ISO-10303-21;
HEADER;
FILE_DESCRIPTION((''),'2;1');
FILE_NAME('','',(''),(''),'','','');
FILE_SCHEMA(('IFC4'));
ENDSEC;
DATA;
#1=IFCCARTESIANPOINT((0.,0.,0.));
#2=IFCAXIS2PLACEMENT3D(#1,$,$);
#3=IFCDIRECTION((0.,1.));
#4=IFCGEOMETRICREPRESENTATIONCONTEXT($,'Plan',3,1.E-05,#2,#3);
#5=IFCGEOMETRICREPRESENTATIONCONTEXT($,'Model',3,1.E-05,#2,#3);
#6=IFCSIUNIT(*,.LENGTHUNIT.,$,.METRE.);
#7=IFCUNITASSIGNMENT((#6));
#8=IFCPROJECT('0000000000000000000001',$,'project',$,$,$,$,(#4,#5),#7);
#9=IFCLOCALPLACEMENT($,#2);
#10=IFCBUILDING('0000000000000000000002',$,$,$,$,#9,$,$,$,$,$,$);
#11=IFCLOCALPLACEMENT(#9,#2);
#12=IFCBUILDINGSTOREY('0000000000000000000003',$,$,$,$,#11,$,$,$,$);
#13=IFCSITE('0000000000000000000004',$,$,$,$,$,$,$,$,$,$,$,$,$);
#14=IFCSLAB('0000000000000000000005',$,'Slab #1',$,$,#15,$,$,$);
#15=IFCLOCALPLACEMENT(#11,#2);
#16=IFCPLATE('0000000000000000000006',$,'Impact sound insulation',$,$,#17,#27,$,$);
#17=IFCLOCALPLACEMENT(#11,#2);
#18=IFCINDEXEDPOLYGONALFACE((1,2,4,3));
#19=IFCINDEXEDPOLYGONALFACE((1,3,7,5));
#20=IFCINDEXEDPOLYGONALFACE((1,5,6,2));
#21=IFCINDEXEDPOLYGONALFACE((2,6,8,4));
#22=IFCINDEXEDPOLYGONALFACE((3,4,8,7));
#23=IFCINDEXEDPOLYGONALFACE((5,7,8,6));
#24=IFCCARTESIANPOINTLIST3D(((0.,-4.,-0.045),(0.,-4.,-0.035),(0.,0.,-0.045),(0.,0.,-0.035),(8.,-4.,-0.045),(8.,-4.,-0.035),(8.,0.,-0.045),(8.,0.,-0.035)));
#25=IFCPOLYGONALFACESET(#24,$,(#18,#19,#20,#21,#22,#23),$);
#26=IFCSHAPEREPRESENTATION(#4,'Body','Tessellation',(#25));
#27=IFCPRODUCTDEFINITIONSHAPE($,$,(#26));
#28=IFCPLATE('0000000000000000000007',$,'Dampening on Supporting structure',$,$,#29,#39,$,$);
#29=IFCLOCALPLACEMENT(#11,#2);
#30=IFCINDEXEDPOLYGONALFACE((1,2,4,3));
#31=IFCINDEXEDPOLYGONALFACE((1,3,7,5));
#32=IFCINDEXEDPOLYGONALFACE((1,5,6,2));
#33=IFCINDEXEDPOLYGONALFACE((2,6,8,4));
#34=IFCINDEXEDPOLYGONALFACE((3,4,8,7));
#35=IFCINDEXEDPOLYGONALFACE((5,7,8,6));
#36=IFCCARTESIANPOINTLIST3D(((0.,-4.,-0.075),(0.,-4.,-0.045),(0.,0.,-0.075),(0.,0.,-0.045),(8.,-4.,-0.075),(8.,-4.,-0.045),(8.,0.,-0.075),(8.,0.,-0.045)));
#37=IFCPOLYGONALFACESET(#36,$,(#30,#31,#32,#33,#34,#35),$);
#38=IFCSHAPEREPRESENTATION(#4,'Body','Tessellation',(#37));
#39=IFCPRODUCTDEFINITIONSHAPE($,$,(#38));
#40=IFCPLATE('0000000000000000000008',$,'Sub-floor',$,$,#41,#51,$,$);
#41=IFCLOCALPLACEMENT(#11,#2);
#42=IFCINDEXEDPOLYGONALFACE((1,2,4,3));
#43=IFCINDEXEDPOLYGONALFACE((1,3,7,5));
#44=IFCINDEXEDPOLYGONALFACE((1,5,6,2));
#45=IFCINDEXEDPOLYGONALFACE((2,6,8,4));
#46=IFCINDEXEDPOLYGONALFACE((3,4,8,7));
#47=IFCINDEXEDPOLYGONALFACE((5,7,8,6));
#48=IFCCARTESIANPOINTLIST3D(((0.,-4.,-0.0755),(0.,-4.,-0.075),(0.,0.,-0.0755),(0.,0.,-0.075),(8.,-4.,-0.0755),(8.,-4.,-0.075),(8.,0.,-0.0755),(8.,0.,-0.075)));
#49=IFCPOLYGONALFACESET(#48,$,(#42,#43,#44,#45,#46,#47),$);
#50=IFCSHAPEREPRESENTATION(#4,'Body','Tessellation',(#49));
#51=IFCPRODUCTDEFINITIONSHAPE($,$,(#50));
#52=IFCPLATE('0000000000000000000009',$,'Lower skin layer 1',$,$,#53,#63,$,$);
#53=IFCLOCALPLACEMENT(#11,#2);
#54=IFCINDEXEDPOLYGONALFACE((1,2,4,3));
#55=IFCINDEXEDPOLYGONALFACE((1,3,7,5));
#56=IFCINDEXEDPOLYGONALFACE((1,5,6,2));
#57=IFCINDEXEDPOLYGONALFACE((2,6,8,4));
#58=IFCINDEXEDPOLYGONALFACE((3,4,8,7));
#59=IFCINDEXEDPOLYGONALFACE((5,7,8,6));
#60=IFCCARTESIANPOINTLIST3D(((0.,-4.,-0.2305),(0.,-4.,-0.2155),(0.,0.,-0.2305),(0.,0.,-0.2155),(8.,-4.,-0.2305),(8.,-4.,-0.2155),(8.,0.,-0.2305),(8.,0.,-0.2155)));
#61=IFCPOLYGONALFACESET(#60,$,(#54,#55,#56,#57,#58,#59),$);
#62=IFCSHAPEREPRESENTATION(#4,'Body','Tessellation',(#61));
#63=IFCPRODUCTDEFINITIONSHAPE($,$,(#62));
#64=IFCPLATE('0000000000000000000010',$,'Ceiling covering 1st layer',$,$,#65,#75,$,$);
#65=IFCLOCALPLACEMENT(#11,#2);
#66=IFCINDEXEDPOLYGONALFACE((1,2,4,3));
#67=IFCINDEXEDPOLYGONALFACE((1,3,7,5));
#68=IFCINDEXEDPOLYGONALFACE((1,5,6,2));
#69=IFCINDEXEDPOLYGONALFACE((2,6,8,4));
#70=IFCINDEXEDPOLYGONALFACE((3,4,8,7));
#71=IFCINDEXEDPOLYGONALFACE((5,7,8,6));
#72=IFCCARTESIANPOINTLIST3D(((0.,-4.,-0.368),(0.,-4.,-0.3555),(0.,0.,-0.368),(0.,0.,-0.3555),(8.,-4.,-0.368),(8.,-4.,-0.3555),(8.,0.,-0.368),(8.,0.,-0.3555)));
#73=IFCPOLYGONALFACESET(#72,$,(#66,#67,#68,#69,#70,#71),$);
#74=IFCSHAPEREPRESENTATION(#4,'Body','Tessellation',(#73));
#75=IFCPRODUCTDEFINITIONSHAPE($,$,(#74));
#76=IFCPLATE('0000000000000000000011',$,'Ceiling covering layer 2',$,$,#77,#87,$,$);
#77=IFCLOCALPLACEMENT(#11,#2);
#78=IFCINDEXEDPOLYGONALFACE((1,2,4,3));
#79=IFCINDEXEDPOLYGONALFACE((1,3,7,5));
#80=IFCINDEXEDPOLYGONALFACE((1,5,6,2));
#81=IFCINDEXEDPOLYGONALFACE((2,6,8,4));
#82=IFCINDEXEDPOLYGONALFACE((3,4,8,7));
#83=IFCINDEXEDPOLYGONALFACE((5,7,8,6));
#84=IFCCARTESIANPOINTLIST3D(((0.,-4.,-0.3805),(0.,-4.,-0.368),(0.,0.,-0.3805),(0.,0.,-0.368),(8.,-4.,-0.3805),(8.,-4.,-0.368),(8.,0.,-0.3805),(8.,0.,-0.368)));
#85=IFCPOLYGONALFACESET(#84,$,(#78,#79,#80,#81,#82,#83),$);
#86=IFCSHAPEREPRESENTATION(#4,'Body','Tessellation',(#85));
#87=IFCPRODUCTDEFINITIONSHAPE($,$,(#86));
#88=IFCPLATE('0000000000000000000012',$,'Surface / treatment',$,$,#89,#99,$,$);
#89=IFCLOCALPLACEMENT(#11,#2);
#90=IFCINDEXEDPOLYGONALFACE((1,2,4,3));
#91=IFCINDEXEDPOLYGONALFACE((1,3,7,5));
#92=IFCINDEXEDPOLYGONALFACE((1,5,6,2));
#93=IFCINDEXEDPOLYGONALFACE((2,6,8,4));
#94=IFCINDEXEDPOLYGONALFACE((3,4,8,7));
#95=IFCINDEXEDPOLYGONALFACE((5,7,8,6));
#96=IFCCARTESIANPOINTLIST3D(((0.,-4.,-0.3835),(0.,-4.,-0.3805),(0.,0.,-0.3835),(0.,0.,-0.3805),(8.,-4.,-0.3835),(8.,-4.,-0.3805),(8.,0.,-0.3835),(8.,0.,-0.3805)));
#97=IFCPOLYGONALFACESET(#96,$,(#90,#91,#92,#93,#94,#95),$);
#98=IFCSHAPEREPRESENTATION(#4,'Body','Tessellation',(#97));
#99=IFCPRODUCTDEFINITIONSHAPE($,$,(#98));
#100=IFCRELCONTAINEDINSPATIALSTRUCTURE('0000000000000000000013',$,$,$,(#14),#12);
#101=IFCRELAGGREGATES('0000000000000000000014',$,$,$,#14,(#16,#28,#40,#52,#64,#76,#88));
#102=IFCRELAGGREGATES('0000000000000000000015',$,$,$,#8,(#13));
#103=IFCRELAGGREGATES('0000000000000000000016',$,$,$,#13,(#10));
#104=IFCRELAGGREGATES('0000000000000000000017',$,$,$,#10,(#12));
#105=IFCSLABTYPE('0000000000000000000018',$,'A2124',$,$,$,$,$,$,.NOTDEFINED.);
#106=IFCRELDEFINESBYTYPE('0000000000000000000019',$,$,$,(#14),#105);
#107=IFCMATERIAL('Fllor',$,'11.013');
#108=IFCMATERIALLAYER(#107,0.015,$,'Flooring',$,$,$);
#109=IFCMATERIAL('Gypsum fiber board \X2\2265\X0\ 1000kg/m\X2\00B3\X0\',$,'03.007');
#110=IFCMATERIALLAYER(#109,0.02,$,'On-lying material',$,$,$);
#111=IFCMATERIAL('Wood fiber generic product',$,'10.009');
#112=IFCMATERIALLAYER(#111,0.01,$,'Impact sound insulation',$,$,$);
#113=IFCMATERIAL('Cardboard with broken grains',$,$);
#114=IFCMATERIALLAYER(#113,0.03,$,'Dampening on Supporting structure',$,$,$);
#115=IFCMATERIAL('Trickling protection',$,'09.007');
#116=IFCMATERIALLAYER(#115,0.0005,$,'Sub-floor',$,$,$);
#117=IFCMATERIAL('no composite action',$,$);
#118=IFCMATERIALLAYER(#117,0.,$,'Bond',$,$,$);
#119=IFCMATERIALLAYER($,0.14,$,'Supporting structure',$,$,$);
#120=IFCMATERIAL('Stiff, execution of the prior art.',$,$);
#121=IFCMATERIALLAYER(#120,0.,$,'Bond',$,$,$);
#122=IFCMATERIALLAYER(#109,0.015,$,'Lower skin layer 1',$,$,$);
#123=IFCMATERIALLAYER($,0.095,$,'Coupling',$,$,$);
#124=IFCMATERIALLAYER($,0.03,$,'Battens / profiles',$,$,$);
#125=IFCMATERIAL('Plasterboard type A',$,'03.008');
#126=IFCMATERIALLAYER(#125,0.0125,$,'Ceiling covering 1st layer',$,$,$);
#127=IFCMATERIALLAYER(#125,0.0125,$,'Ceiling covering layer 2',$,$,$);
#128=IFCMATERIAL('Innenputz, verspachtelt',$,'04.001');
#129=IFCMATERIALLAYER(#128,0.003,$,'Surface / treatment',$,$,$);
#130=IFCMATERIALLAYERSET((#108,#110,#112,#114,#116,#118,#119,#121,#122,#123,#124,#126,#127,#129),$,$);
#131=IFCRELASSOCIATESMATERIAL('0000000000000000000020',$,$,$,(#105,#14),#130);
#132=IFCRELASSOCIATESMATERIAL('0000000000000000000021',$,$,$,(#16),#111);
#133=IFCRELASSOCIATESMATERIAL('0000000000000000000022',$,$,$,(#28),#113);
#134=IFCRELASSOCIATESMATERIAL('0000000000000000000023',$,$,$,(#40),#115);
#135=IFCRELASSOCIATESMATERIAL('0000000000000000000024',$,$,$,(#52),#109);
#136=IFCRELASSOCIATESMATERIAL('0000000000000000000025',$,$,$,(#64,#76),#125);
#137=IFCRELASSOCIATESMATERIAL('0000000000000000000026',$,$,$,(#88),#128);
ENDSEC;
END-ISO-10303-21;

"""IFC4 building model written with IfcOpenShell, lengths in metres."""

from ifc_helpers import new_model, si_unit, direction, frame, frame_2d, origin, place, context, project, spatial, rectangle, extrude, material, layer, layer_set, type_object, element, aggregate, save


model = new_model("IFC4")

# Units and contexts
plan_context = context("Plan", 3, precision=1e-05, world=origin(), true_north=direction((0.0, 1.0)))
model_context = context("Model", 3, precision=1e-05, world=origin(), true_north=direction((0.0, 1.0)))
ifc_project = project(units=[si_unit("LENGTHUNIT", "METRE")], contexts=[plan_context, model_context])

# Site, building, storey
site = spatial("IfcSite", under=ifc_project)
building_placement = place(None, origin())
building = spatial("IfcBuilding", under=site, at=building_placement)
storey_placement = place(building_placement, origin())
storey = spatial("IfcBuildingStorey", under=building, at=storey_placement)

# Slab, plates
ifc_material_1 = material(Name="Fllor", Category="11.013")
ifc_layer_1 = layer(ifc_material_1, 0.015, Name="Flooring")
ifc_material_2 = material(Name="Gypsum fiber board ≥ 1000kg/m³", Category="03.007")
ifc_layer_2 = layer(ifc_material_2, 0.02, Name="On-lying material")
ifc_material_3 = material(Name="Wood fiber generic product", Category="10.009")
ifc_layer_3 = layer(ifc_material_3, 0.01, Name="Impact sound insulation")
ifc_material_4 = material(Name="Cardboard with broken grains")
ifc_layer_4 = layer(ifc_material_4, 0.03, Name="Dampening on Supporting structure")
ifc_material_5 = material(Name="Trickling protection", Category="09.007")
ifc_layer_5 = layer(ifc_material_5, 0.0005, Name="Sub-floor")
ifc_material_6 = material(Name="no composite action")
ifc_layer_6 = layer(ifc_material_6, 0.0, Name="Bond")
ifc_layer_7 = layer(None, 0.14, Name="Supporting structure")
ifc_material_7 = material(Name="Stiff, execution of the prior art.")
ifc_layer_8 = layer(ifc_material_7, 0.0, Name="Bond")
ifc_layer_9 = layer(ifc_material_2, 0.015, Name="Lower skin layer 1")
ifc_layer_10 = layer(None, 0.095, Name="Coupling")
ifc_layer_11 = layer(None, 0.03, Name="Battens / profiles")
ifc_material_8 = material(Name="Plasterboard type A", Category="03.008")
ifc_layer_12 = layer(ifc_material_8, 0.0125, Name="Ceiling covering 1st layer")
ifc_layer_13 = layer(ifc_material_8, 0.0125, Name="Ceiling covering layer 2")
ifc_material_9 = material(Name="Innenputz, verspachtelt", Category="04.001")
ifc_layer_14 = layer(ifc_material_9, 0.003, Name="Surface / treatment")
ifc_layer_set = layer_set([ifc_layer_1, ifc_layer_2, ifc_layer_3, ifc_layer_4, ifc_layer_5, ifc_layer_6, ifc_layer_7, ifc_layer_8, ifc_layer_9, ifc_layer_10, ifc_layer_11, ifc_layer_12, ifc_layer_13, ifc_layer_14])
slab_type = type_object("IfcSlabType", Name="A2124", PredefinedType="NOTDEFINED", material=ifc_layer_set)
slab_placement = place(None, frame((0.0, 0.0, 0.0), z_axis=(0.0, 0.0, -1.0), x_axis=(1.0, 0.0, 0.0)))
slab = element("IfcSlab", 1, at=slab_placement, inside=storey, type_object=slab_type, material=ifc_layer_set, Name="Slab #1")
plate_1_placement = place(slab_placement, origin())
plate_1 = element("IfcPlate", 2, at=plate_1_placement, material=ifc_material_3, Name="Impact sound insulation", context=plan_context, shape_type="SweptSolid", body=[
    extrude(rectangle(XDim=8.0, YDim=4.0, at=frame_2d((4.0, 2.0), x_axis=(1.0, 0.0))), frame((0.0, 0.0, 0.035), z_axis=(0.0, 0.0, 1.0), x_axis=(1.0, 0.0, 0.0)), (0.0, 0.0, 1.0), 0.01),
])
plate_2_placement = place(slab_placement, origin())
plate_2 = element("IfcPlate", 3, at=plate_2_placement, material=ifc_material_4, Name="Dampening on Supporting structure", context=plan_context, shape_type="SweptSolid", body=[
    extrude(rectangle(XDim=8.0, YDim=4.0, at=frame_2d((4.0, 2.0), x_axis=(1.0, 0.0))), frame((0.0, 0.0, 0.045), z_axis=(0.0, 0.0, 1.0), x_axis=(1.0, 0.0, 0.0)), (0.0, 0.0, 1.0), 0.03),
])
plate_3_placement = place(slab_placement, origin())
plate_3 = element("IfcPlate", 4, at=plate_3_placement, material=ifc_material_5, Name="Sub-floor", context=plan_context, shape_type="SweptSolid", body=[
    extrude(rectangle(XDim=8.0, YDim=4.0, at=frame_2d((4.0, 2.0), x_axis=(1.0, 0.0))), frame((0.0, 0.0, 0.075), z_axis=(0.0, 0.0, 1.0), x_axis=(1.0, 0.0, 0.0)), (0.0, 0.0, 1.0), 0.0005),
])
plate_4_placement = place(slab_placement, origin())
plate_4 = element("IfcPlate", 5, at=plate_4_placement, material=ifc_material_2, Name="Lower skin layer 1", context=plan_context, shape_type="SweptSolid", body=[
    extrude(rectangle(XDim=8.0, YDim=4.0, at=frame_2d((4.0, 2.0), x_axis=(1.0, 0.0))), frame((0.0, 0.0, 0.2155), z_axis=(0.0, 0.0, 1.0), x_axis=(1.0, 0.0, 0.0)), (0.0, 0.0, 1.0), 0.015),
])
plate_5_placement = place(slab_placement, origin())
plate_5 = element("IfcPlate", 6, at=plate_5_placement, material=ifc_material_8, Name="Ceiling covering 1st layer", context=plan_context, shape_type="SweptSolid", body=[
    extrude(rectangle(XDim=8.0, YDim=4.0, at=frame_2d((4.0, 2.0), x_axis=(1.0, 0.0))), frame((0.0, 0.0, 0.3555), z_axis=(0.0, 0.0, 1.0), x_axis=(1.0, 0.0, 0.0)), (0.0, 0.0, 1.0), 0.0125),
])
plate_6_placement = place(slab_placement, origin())
plate_6 = element("IfcPlate", 7, at=plate_6_placement, material=ifc_material_8, Name="Ceiling covering layer 2", context=plan_context, shape_type="SweptSolid", body=[
    extrude(rectangle(XDim=8.0, YDim=4.0, at=frame_2d((4.0, 2.0), x_axis=(1.0, 0.0))), frame((0.0, 0.0, 0.368), z_axis=(0.0, 0.0, 1.0), x_axis=(1.0, 0.0, 0.0)), (0.0, 0.0, 1.0), 0.0125),
])
plate_7_placement = place(slab_placement, origin())
plate_7 = element("IfcPlate", 8, at=plate_7_placement, material=ifc_material_9, Name="Surface / treatment", context=plan_context, shape_type="SweptSolid", body=[
    extrude(rectangle(XDim=8.0, YDim=4.0, at=frame_2d((4.0, 2.0), x_axis=(1.0, 0.0))), frame((0.0, 0.0, 0.3805), z_axis=(0.0, 0.0, 1.0), x_axis=(1.0, 0.0, 0.0)), (0.0, 0.0, 1.0), 0.003),
])
aggregate(slab, [plate_1, plate_2, plate_3, plate_4, plate_5, plate_6, plate_7])

save(model, "model.ifc")
